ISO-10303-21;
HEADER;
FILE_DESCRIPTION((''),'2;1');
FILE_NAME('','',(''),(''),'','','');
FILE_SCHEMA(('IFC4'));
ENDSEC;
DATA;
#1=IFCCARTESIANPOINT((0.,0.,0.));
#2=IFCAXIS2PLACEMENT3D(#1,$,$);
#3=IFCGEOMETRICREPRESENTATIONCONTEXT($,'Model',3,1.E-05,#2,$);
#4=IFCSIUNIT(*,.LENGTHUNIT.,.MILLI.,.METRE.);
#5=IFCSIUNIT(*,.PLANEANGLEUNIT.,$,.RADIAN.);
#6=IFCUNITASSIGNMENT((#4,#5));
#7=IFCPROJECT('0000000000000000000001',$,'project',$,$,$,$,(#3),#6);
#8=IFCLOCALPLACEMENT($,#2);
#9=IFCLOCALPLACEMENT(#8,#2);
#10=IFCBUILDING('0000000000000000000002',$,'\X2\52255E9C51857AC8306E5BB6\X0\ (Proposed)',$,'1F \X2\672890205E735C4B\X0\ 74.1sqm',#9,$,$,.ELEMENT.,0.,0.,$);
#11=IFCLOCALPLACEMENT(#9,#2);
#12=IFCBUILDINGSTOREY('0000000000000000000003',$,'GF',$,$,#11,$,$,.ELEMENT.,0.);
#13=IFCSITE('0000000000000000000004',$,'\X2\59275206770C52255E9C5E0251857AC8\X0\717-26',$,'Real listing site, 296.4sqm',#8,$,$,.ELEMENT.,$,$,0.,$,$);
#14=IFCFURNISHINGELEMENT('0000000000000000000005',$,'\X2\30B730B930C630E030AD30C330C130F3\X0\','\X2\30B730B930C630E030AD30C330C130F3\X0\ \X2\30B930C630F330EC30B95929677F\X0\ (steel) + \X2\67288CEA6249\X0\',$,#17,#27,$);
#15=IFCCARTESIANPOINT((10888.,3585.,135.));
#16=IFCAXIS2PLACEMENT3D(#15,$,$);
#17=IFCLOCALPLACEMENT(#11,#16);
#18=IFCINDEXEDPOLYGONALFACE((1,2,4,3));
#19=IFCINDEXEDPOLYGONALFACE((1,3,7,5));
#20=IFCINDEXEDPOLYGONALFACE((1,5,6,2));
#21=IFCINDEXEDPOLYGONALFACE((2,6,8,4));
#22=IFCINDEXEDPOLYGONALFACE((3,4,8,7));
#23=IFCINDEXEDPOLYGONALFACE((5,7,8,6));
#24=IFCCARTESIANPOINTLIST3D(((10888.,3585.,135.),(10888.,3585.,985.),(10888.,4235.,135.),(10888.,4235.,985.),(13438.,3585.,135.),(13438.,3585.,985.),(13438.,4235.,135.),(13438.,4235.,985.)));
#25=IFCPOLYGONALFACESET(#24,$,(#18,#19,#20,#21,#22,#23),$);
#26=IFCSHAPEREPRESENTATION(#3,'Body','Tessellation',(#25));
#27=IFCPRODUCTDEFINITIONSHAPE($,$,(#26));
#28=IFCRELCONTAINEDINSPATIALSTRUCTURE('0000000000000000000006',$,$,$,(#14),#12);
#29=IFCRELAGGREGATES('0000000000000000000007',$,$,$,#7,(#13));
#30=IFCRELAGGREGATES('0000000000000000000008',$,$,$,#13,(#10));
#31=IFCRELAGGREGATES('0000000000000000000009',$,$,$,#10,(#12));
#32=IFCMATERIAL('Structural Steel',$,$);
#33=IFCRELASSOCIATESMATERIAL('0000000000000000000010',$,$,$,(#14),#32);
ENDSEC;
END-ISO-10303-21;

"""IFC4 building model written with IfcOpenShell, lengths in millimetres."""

from ifc_helpers import new_model, si_unit, frame, frame_2d, origin, place, context, project, spatial, rectangle, extrude, material, element, save


model = new_model("IFC4")

# Units and contexts
model_context = context("Model", 3, precision=1e-05, world=origin())
ifc_project = project(units=[si_unit("LENGTHUNIT", "METRE", prefix="MILLI"), si_unit("PLANEANGLEUNIT", "RADIAN")], contexts=[model_context])

# Site, building, storey
site_placement = place(None, origin())
site = spatial("IfcSite", under=ifc_project, at=site_placement, Name="大分県別府市内竈717-26", ObjectType="Real listing site, 296.4sqm", CompositionType="ELEMENT", RefElevation=0.0)
building_placement = place(site_placement, origin())
building = spatial("IfcBuilding", under=site, at=building_placement, Name="別府内竈の家 (Proposed)", ObjectType="1F 木造平屋 74.1sqm", CompositionType="ELEMENT", ElevationOfRefHeight=0.0, ElevationOfTerrain=0.0)
storey_placement = place(building_placement, origin())
storey = spatial("IfcBuildingStorey", under=building, at=storey_placement, Name="GF", CompositionType="ELEMENT", Elevation=0.0)

# Furnishing element
ifc_material_1 = material(Name="Structural Steel")
furnishing_1_placement = place(storey_placement, frame((10888.0, 3585.0, 135.0)))
element("IfcFurnishingElement", 1, at=furnishing_1_placement, inside=storey, material=ifc_material_1, Name="システムキッチン", Description="システムキッチン ステンレス天板 (steel) + 木質扉", context=model_context, shape_type="SweptSolid", body=[
    extrude(rectangle(XDim=2550.0, YDim=650.0, at=frame_2d((1275.0, 325.0))), frame((10888.0, 3585.0, 135.0)), (0.0, 0.0, 1.0), 850.0),
])

save(model, "model.ifc")
